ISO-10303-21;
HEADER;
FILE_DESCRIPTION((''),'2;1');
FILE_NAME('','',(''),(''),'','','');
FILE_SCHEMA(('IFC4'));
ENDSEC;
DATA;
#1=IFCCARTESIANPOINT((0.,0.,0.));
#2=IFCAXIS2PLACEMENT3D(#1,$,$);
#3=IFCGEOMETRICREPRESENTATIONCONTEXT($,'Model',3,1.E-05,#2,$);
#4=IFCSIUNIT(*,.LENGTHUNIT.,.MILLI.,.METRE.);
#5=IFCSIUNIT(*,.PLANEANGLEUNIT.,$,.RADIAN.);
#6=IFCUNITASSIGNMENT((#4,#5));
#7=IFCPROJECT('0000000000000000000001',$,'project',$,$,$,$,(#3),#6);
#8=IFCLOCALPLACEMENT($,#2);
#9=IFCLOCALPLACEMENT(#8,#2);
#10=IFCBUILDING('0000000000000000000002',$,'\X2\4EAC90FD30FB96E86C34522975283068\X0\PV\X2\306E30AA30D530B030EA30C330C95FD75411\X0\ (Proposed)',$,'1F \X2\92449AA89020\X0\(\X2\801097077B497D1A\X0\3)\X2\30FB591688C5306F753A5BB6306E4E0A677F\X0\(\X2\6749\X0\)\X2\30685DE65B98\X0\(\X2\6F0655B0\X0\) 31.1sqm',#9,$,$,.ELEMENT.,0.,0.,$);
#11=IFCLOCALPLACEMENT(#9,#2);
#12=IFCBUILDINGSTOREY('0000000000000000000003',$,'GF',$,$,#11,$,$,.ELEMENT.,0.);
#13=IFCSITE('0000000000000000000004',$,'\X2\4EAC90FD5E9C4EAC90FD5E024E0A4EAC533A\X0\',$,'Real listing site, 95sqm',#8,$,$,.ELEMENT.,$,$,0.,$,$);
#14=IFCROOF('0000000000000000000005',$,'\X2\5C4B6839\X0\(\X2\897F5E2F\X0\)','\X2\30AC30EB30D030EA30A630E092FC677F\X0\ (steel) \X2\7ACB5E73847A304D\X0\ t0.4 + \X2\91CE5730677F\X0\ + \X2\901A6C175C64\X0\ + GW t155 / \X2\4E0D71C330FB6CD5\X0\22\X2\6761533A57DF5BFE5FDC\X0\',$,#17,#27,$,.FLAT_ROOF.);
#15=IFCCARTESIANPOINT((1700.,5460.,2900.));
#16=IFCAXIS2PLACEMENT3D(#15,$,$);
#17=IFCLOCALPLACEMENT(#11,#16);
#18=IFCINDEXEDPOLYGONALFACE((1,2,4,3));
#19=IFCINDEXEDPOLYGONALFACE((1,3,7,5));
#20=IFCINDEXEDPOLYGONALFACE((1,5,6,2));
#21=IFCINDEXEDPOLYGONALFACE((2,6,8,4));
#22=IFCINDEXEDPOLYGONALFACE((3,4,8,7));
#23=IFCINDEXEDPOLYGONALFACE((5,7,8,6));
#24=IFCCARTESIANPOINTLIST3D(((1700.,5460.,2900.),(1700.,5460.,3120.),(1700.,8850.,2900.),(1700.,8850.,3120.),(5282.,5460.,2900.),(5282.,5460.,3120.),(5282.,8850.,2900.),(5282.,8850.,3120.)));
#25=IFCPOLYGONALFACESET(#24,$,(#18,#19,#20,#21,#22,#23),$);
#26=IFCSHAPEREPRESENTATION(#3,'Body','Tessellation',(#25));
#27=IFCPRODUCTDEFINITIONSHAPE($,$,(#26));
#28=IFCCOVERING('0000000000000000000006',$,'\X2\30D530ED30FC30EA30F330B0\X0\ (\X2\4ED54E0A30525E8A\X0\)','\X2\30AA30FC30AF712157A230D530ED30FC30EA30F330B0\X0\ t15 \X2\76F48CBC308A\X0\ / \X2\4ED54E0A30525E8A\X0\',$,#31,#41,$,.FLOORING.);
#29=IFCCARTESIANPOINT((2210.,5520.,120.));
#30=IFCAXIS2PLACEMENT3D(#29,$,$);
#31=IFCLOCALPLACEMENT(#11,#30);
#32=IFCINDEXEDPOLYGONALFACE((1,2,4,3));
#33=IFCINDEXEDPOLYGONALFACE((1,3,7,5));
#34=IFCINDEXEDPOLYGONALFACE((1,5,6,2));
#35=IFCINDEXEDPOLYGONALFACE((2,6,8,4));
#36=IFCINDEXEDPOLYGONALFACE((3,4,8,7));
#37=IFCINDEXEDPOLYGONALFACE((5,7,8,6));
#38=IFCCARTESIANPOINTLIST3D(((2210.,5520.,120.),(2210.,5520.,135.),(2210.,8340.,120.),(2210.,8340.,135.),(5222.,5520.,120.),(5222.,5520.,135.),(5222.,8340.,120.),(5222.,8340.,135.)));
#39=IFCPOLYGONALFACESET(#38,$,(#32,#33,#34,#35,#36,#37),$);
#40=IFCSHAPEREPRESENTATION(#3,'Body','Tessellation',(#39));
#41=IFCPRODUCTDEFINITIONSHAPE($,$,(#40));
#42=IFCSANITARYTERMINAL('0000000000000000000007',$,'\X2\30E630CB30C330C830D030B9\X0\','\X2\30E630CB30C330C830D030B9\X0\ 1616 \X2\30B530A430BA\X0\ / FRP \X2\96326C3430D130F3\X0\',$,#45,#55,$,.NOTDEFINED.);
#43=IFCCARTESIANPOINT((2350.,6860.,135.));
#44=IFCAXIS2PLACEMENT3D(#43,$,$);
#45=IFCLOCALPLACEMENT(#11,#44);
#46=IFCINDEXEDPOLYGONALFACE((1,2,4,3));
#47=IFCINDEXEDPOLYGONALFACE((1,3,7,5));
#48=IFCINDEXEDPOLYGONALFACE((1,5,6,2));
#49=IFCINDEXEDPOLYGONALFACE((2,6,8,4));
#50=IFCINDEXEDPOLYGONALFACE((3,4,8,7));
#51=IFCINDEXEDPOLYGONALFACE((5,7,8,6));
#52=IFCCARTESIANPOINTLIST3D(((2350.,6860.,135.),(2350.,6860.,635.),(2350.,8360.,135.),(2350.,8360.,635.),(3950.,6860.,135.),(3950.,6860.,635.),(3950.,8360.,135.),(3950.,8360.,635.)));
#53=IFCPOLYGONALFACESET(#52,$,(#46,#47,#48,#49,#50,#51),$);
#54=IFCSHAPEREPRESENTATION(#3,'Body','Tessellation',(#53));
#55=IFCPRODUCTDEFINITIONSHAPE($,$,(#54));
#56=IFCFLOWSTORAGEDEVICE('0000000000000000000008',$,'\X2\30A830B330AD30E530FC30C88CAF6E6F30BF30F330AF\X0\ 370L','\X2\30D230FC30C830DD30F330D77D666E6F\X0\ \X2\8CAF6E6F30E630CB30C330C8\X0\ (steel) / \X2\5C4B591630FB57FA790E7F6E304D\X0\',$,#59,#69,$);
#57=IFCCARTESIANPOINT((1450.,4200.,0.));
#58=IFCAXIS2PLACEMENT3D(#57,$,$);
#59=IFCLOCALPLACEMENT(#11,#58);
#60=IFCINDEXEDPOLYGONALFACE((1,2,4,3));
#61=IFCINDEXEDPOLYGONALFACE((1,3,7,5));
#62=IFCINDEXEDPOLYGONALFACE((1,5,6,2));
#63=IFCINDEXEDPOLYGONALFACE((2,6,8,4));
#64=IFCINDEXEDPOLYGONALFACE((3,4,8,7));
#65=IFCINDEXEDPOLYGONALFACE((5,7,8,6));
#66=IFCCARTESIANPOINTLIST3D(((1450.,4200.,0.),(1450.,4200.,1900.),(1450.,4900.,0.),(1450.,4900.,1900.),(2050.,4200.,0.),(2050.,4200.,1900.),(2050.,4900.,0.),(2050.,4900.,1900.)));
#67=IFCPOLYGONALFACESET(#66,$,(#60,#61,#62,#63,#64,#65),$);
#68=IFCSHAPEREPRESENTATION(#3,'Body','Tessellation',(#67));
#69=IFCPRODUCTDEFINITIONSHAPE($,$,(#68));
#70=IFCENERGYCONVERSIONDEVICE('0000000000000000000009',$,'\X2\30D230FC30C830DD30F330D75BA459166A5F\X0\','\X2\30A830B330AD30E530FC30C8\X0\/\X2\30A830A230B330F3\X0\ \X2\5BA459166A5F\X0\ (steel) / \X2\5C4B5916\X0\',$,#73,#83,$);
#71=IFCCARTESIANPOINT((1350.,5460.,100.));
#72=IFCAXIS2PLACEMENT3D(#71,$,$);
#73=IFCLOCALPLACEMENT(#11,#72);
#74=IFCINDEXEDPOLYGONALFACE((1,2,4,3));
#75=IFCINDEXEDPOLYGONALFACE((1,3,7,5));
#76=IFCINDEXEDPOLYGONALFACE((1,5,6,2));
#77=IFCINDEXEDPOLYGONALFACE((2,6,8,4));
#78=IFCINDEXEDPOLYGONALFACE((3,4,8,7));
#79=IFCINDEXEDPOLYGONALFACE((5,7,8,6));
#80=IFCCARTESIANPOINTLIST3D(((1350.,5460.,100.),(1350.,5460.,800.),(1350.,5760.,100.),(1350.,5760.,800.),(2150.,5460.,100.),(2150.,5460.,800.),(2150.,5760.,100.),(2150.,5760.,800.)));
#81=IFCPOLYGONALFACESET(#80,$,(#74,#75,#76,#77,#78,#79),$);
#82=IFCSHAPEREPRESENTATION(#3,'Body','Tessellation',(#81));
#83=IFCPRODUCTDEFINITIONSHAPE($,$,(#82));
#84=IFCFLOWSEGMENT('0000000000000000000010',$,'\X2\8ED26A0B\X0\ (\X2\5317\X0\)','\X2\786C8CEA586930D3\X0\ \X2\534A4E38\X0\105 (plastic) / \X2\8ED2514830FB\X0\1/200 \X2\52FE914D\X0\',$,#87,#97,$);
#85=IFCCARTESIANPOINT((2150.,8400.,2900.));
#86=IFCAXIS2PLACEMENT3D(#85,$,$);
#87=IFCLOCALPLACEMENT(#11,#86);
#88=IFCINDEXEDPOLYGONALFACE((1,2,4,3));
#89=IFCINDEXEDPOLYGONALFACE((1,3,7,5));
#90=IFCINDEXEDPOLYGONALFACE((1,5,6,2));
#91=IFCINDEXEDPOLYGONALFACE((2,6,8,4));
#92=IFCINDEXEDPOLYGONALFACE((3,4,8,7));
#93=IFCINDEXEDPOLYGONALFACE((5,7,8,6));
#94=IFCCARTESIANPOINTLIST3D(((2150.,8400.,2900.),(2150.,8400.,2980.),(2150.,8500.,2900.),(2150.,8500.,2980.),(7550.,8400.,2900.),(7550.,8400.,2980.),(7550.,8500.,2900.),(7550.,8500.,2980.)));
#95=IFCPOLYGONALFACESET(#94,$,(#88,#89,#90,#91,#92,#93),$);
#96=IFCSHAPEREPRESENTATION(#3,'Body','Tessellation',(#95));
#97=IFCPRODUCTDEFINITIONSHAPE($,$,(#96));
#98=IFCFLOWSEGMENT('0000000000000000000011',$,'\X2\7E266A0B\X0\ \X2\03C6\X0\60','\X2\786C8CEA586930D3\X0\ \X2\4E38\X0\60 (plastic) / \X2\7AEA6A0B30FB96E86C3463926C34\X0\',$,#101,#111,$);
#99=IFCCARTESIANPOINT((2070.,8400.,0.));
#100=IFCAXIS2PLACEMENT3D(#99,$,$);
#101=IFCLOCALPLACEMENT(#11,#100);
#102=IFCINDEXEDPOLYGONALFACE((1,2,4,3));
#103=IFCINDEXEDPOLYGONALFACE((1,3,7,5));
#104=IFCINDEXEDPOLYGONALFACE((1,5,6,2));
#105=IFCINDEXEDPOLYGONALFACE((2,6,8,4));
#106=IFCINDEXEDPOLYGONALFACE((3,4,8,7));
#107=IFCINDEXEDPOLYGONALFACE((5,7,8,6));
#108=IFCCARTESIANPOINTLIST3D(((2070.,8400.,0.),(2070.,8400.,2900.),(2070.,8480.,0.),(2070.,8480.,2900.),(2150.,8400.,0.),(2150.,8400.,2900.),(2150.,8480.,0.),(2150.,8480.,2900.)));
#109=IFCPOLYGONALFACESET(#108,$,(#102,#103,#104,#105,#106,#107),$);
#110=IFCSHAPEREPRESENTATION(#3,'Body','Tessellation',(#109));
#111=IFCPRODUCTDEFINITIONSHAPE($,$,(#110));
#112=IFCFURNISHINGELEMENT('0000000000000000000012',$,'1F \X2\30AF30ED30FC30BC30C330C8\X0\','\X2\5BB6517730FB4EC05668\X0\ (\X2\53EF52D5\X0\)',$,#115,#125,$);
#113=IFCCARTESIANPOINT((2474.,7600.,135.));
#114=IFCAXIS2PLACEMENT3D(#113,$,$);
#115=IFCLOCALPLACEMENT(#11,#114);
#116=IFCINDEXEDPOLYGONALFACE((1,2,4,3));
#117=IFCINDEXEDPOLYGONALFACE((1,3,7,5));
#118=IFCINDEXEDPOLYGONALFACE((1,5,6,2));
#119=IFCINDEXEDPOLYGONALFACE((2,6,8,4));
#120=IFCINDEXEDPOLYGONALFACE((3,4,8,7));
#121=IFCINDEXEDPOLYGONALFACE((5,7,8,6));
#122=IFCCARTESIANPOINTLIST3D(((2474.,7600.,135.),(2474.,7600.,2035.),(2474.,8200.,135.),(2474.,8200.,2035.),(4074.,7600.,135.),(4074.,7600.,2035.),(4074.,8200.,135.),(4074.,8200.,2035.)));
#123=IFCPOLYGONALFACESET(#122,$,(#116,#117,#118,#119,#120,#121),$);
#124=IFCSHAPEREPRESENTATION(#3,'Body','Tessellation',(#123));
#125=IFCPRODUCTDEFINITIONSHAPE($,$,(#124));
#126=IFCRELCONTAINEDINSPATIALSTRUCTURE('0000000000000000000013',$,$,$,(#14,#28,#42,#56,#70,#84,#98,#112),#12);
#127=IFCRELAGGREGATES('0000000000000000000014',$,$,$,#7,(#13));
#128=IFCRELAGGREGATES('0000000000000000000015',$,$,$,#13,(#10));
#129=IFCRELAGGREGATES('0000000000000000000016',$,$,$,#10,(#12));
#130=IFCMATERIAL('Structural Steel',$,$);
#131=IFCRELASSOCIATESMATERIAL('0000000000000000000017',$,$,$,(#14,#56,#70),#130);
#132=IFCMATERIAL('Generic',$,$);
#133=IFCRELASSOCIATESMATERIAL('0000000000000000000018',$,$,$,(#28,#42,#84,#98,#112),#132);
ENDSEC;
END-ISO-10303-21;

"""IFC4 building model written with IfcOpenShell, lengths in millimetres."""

from ifc_helpers import new_model, si_unit, frame, frame_2d, origin, place, context, project, spatial, rectangle, extrude, material, element, save


model = new_model("IFC4")

# Units and contexts
model_context = context("Model", 3, precision=1e-05, world=origin())
ifc_project = project(units=[si_unit("LENGTHUNIT", "METRE", prefix="MILLI"), si_unit("PLANEANGLEUNIT", "RADIAN")], contexts=[model_context])

# Site, building, storey
site_placement = place(None, origin())
site = spatial("IfcSite", under=ifc_project, at=site_placement, Name="京都府京都市上京区", ObjectType="Real listing site, 95sqm", CompositionType="ELEMENT", RefElevation=0.0)
building_placement = place(site_placement, origin())
building = spatial("IfcBuilding", under=site, at=building_placement, Name="京都・雨水利用とPVのオフグリッド志向 (Proposed)", ObjectType="1F 鉄骨造(耐震等級3)・外装は町家の上板(杉)と左官(漆喰) 31.1sqm", CompositionType="ELEMENT", ElevationOfRefHeight=0.0, ElevationOfTerrain=0.0)
storey_placement = place(building_placement, origin())
storey = spatial("IfcBuildingStorey", under=building, at=storey_placement, Name="GF", CompositionType="ELEMENT", Elevation=0.0)

# Roof
ifc_material_1 = material(Name="Structural Steel")
roof_placement = place(storey_placement, frame((1700.0, 5460.0, 2900.0)))
element("IfcRoof", 1, at=roof_placement, inside=storey, material=ifc_material_1, Name="屋根(西帯)", Description="ガルバリウム鋼板 (steel) 立平葺き t0.4 + 野地板 + 通気層 + GW t155 / 不燃・法22条区域対応", PredefinedType="FLAT_ROOF", context=model_context, shape_type="SweptSolid", body=[
    extrude(rectangle(XDim=3582.0, YDim=3390.0, at=frame_2d((1791.0, 1695.0))), frame((1700.0, 5460.0, 2900.0)), (0.0, 0.0, 1.0), 220.0),
])

# Covering
ifc_material_2 = material(Name="Generic")
covering_placement = place(storey_placement, frame((2210.0, 5520.0, 120.0)))
element("IfcCovering", 2, at=covering_placement, inside=storey, material=ifc_material_2, Name="フローリング (仕上げ床)", Description="オーク無垢フローリング t15 直貼り / 仕上げ床", PredefinedType="FLOORING", context=model_context, shape_type="SweptSolid", body=[
    extrude(rectangle(XDim=3012.0, YDim=2820.0, at=frame_2d((1506.0, 1410.0))), frame((2210.0, 5520.0, 120.0)), (0.0, 0.0, 1.0), 15.0),
])

# Sanitary terminal
sanitary_terminal_placement = place(storey_placement, frame((2350.0, 6860.0, 135.0)))
element("IfcSanitaryTerminal", 3, at=sanitary_terminal_placement, inside=storey, material=ifc_material_2, Name="ユニットバス", Description="ユニットバス 1616 サイズ / FRP 防水パン", PredefinedType="NOTDEFINED", context=model_context, shape_type="SweptSolid", body=[
    extrude(rectangle(XDim=1600.0, YDim=1500.0, at=frame_2d((800.0, 750.0))), frame((2350.0, 6860.0, 135.0)), (0.0, 0.0, 1.0), 500.0),
])

# Flow storage device
flow_storage_device_placement = place(storey_placement, frame((1450.0, 4200.0, 0.0)))
element("IfcFlowStorageDevice", 4, at=flow_storage_device_placement, inside=storey, material=ifc_material_1, Name="エコキュート貯湯タンク 370L", Description="ヒートポンプ給湯 貯湯ユニット (steel) / 屋外・基礎置き", context=model_context, shape_type="SweptSolid", body=[
    extrude(rectangle(XDim=600.0, YDim=700.0, at=frame_2d((300.0, 350.0))), frame((1450.0, 4200.0, 0.0)), (0.0, 0.0, 1.0), 1900.0),
])

# Energy conversion device
energy_conversion_device_placement = place(storey_placement, frame((1350.0, 5460.0, 100.0)))
element("IfcEnergyConversionDevice", 5, at=energy_conversion_device_placement, inside=storey, material=ifc_material_1, Name="ヒートポンプ室外機", Description="エコキュート/エアコン 室外機 (steel) / 屋外", context=model_context, shape_type="SweptSolid", body=[
    extrude(rectangle(XDim=800.0, YDim=300.0, at=frame_2d((400.0, 150.0))), frame((1350.0, 5460.0, 100.0)), (0.0, 0.0, 1.0), 700.0),
])

# Flow segments
flow_segment_1_placement = place(storey_placement, frame((2150.0, 8400.0, 2900.0)))
element("IfcFlowSegment", 6, at=flow_segment_1_placement, inside=storey, material=ifc_material_2, Name="軒樋 (北)", Description="硬質塩ビ 半丸105 (plastic) / 軒先・1/200 勾配", context=model_context, shape_type="SweptSolid", body=[
    extrude(rectangle(XDim=5400.0, YDim=100.0, at=frame_2d((2700.0, 50.0))), frame((2150.0, 8400.0, 2900.0)), (0.0, 0.0, 1.0), 80.0),
])
flow_segment_2_placement = place(storey_placement, frame((2070.0, 8400.0, 0.0)))
element("IfcFlowSegment", 7, at=flow_segment_2_placement, inside=storey, material=ifc_material_2, Name="縦樋 φ60", Description="硬質塩ビ 丸60 (plastic) / 竪樋・雨水排水", context=model_context, shape_type="SweptSolid", body=[
    extrude(rectangle(XDim=80.0, YDim=80.0, at=frame_2d((40.0, 40.0))), frame((2070.0, 8400.0, 0.0)), (0.0, 0.0, 1.0), 2900.0),
])

# Furnishing element
furnishing_placement = place(storey_placement, frame((2474.0, 7600.0, 135.0)))
element("IfcFurnishingElement", 8, at=furnishing_placement, inside=storey, material=ifc_material_2, Name="1F クローゼット", Description="家具・什器 (可動)", context=model_context, shape_type="SweptSolid", body=[
    extrude(rectangle(XDim=1600.0, YDim=600.0, at=frame_2d((800.0, 300.0))), frame((2474.0, 7600.0, 135.0)), (0.0, 0.0, 1.0), 1900.0),
])

save(model, "model.ifc")
